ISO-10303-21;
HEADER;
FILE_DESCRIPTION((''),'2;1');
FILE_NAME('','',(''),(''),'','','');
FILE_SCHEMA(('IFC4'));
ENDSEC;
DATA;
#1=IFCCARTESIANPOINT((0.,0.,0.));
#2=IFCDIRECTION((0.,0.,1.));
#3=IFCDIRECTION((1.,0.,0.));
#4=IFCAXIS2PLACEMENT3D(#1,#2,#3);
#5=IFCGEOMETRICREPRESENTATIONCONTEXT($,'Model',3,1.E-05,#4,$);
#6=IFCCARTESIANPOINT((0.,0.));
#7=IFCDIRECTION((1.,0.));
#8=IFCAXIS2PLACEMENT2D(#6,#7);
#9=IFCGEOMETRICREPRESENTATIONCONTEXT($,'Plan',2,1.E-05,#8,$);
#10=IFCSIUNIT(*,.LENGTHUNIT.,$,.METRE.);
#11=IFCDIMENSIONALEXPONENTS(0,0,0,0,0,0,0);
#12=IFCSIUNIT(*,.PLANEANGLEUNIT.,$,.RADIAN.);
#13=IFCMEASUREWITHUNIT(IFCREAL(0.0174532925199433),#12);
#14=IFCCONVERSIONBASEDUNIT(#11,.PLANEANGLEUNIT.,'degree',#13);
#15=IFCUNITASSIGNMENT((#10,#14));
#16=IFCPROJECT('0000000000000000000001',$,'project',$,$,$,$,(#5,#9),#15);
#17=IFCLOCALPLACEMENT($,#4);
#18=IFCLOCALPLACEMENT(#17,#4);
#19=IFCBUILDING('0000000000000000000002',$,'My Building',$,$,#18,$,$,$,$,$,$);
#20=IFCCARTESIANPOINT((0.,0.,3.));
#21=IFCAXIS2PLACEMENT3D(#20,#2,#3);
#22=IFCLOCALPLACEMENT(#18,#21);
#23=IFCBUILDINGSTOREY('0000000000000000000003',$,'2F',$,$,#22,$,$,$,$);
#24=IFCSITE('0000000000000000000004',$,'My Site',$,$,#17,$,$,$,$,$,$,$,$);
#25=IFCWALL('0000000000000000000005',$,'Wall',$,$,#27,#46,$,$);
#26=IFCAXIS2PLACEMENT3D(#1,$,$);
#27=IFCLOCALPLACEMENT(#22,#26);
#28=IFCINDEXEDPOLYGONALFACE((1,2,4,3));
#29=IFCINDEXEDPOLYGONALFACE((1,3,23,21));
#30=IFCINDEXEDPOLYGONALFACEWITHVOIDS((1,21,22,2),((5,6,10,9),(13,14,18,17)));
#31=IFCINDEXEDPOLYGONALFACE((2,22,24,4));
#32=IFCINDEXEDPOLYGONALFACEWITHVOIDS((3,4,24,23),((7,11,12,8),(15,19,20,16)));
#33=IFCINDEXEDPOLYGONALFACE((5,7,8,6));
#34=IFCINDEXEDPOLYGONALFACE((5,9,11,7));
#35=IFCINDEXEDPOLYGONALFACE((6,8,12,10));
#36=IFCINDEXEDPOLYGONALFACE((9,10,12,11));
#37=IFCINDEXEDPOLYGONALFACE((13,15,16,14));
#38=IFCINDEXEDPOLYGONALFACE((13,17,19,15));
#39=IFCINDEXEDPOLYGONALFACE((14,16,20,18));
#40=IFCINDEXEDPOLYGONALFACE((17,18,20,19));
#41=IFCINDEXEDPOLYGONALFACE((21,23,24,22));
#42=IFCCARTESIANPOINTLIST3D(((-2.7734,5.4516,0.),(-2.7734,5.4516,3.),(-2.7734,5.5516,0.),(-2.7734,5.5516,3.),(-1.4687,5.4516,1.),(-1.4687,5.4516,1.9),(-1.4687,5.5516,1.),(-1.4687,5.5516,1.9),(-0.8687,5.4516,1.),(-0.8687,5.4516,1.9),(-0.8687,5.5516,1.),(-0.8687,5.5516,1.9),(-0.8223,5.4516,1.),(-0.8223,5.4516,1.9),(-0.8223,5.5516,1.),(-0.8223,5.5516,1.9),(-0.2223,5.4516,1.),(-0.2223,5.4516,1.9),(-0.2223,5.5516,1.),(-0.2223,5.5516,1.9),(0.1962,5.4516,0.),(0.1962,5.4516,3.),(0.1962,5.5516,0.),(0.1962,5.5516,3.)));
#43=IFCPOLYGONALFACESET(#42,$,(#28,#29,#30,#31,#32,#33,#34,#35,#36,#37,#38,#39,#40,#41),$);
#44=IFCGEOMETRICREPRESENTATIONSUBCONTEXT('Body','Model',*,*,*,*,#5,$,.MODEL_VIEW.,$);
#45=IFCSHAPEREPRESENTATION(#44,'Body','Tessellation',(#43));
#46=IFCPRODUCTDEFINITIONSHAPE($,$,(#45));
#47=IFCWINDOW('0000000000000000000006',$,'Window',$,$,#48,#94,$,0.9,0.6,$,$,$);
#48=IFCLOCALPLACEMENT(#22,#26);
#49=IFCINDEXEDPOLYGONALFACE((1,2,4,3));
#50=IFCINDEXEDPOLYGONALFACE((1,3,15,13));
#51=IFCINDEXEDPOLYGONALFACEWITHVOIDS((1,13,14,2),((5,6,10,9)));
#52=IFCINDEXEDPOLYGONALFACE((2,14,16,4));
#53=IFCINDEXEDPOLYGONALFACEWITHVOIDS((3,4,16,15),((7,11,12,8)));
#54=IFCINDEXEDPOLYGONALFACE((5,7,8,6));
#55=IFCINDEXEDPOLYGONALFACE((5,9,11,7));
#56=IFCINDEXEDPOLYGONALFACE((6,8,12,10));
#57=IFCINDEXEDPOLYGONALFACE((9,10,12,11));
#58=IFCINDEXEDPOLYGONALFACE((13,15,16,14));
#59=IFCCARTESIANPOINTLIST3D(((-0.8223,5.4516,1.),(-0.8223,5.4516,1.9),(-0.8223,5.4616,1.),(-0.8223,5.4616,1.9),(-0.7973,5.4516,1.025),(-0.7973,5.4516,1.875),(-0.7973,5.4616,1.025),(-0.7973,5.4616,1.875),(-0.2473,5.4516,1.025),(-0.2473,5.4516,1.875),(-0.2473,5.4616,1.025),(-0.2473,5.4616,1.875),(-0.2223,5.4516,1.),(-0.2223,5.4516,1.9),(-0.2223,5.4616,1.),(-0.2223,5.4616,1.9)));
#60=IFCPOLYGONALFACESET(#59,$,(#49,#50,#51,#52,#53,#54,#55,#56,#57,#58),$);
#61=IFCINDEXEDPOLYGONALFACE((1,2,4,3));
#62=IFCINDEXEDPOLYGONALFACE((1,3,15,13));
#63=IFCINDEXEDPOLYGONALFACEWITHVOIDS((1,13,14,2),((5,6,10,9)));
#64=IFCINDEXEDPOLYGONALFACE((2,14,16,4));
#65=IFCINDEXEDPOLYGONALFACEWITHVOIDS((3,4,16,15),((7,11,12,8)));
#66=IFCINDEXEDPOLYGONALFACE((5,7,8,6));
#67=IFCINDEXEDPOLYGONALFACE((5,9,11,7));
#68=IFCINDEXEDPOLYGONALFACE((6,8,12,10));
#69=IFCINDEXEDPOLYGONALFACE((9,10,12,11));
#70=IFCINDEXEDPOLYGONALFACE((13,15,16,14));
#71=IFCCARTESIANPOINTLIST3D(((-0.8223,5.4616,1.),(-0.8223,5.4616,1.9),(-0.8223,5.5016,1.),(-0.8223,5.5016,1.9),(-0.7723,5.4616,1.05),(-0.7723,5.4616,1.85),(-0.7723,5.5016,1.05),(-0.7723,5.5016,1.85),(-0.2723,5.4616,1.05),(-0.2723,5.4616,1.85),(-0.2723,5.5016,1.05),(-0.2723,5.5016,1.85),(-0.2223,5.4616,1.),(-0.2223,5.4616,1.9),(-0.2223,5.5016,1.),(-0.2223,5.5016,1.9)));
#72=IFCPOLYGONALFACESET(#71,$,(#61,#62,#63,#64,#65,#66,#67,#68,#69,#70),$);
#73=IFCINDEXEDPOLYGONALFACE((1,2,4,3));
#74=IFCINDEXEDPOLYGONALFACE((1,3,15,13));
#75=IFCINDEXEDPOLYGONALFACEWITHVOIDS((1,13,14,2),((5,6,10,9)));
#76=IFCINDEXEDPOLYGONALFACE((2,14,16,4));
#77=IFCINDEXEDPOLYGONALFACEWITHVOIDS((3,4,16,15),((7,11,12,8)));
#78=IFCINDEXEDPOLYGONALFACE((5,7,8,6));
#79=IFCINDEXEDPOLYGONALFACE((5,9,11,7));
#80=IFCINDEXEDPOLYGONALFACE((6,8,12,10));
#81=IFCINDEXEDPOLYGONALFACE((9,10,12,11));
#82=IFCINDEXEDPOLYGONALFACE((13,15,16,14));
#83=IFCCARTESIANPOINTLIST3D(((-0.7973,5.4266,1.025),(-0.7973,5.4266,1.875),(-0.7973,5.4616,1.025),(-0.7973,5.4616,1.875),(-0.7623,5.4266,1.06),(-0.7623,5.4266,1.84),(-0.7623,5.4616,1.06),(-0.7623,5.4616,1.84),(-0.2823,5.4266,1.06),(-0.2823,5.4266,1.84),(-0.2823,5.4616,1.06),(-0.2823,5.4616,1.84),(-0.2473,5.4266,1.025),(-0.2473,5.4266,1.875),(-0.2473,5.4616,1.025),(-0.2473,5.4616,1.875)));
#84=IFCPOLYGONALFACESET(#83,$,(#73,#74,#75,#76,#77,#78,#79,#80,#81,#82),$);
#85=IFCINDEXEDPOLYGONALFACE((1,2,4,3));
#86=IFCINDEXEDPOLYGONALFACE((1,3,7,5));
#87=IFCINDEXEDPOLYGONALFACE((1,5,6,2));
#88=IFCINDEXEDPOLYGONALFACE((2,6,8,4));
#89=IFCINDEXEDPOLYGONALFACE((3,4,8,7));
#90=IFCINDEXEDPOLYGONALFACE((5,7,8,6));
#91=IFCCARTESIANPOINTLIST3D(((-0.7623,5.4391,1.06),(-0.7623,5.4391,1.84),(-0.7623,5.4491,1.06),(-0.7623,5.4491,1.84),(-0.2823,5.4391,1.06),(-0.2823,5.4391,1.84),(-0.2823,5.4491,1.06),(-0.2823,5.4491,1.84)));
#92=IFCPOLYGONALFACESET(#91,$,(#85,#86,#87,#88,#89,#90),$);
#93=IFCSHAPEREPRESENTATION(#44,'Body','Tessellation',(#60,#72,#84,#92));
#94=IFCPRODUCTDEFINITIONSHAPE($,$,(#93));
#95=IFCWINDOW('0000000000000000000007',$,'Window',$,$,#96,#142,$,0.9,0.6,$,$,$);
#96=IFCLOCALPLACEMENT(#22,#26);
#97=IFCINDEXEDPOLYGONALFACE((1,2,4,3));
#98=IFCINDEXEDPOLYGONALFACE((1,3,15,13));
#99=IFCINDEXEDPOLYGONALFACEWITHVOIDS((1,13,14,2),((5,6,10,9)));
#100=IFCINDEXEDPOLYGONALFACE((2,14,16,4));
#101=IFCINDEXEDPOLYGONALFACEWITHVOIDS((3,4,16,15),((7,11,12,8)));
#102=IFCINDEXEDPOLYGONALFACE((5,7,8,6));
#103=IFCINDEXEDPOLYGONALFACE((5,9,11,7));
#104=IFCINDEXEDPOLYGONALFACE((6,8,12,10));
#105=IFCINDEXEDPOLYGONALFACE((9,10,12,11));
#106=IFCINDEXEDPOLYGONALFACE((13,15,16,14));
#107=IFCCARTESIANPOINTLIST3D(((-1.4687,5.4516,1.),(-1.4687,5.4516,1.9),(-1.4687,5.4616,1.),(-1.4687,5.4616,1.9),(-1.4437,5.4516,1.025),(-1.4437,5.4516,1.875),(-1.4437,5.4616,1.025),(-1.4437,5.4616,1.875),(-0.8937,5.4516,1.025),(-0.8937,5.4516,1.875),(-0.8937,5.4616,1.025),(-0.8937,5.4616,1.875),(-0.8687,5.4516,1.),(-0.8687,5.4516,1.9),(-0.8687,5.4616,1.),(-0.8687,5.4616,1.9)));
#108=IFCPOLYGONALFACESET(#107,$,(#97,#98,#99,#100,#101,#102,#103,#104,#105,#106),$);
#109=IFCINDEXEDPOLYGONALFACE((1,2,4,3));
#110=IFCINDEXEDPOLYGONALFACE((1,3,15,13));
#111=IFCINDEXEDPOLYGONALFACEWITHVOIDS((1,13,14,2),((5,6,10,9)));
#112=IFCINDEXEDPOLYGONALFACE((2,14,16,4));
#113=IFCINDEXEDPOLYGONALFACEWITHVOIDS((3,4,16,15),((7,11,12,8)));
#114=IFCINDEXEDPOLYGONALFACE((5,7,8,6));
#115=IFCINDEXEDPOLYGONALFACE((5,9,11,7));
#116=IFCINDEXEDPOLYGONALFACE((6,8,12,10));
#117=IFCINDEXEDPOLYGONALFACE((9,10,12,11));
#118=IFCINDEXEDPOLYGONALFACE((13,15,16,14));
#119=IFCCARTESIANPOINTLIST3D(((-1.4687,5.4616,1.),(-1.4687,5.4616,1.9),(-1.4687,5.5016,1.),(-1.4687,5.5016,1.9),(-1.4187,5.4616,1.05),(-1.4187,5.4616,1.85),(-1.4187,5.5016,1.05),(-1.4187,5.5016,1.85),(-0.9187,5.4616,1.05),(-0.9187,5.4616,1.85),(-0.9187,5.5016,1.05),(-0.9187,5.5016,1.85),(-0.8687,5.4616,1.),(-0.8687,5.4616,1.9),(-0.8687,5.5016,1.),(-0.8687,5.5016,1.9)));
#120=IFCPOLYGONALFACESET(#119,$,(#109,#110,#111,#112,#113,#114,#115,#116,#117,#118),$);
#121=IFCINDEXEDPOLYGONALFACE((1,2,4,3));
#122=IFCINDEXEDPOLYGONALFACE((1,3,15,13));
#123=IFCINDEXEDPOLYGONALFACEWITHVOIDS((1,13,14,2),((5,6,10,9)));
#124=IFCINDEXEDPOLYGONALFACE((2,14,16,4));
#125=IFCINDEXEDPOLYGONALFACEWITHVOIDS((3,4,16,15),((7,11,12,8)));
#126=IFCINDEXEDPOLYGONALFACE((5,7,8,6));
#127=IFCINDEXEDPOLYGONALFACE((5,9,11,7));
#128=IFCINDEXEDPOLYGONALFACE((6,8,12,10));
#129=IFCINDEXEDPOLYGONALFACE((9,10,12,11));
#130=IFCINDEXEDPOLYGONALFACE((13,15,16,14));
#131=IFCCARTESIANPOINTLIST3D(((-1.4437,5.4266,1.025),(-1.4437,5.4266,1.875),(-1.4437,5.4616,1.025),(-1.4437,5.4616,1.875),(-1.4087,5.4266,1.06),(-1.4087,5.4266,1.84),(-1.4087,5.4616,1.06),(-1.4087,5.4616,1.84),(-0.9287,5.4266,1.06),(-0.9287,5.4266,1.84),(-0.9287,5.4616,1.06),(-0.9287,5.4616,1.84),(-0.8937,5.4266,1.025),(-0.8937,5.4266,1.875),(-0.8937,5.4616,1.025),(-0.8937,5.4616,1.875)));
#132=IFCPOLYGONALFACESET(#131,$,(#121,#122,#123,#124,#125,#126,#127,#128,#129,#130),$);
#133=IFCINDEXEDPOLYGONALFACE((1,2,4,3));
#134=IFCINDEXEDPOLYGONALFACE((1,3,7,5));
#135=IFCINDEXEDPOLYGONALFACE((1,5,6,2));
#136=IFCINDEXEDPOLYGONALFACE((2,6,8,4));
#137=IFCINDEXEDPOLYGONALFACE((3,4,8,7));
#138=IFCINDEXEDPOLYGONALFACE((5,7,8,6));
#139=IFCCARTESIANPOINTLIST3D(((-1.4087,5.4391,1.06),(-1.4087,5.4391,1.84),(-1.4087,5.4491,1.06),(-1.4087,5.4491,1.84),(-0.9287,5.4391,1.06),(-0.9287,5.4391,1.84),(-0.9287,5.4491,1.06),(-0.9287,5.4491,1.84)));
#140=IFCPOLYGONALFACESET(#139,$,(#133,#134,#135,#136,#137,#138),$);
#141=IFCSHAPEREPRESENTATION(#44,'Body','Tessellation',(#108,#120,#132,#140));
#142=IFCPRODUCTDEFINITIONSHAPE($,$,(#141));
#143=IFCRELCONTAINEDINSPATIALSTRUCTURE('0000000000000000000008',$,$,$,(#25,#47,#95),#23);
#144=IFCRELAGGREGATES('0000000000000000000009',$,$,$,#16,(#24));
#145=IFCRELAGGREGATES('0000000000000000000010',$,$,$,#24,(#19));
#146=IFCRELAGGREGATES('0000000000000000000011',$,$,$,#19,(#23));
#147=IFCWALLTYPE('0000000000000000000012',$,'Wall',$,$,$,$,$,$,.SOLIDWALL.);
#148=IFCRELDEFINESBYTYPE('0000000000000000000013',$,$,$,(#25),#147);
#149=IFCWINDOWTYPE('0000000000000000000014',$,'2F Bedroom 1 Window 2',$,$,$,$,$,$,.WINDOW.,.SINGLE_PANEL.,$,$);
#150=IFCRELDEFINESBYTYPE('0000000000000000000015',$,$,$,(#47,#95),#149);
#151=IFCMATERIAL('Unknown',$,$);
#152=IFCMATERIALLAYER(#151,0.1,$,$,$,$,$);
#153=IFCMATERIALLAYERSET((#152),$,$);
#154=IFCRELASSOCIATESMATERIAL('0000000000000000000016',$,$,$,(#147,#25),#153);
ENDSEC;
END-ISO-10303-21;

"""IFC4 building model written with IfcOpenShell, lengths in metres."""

from ifc_helpers import new_model, entity, si_unit, converted_unit, frame, origin_with_axes, origin_2d_with_axis, place, context, subcontext, project, spatial, line, indexed_curve, outline, extrude, shape, source, transform, mapped, material, layer, layer_set, layer_usage, type_object, type_shapes, element, fill, save


model = new_model("IFC4")

# Units and contexts
model_context = context("Model", 3, precision=1e-05, world=origin_with_axes())
plan_context = context("Plan", 2, precision=1e-05, world=origin_2d_with_axis())
body_context_1 = subcontext(model_context, "Body", "Model", "MODEL_VIEW")
body_context_2 = subcontext(plan_context, "Body", "Plan", "PLAN_VIEW")
ifc_project = project(units=[si_unit("LENGTHUNIT", "METRE"), converted_unit("PLANEANGLEUNIT", "degree", entity("IfcReal", 0.0174532925199433), si_unit("PLANEANGLEUNIT", "RADIAN"), dimensions=[0, 0, 0, 0, 0, 0, 0])], contexts=[model_context, plan_context])

# Site, building, storey
site_placement = place(None, origin_with_axes())
site = spatial("IfcSite", under=ifc_project, at=site_placement, Name="My Site")
building_placement = place(site_placement, origin_with_axes())
building = spatial("IfcBuilding", under=site, at=building_placement, Name="My Building")
storey_placement = place(building_placement, frame((0.0, 0.0, 3.0), z_axis=(0.0, 0.0, 1.0), x_axis=(1.0, 0.0, 0.0)))
storey = spatial("IfcBuildingStorey", under=building, at=storey_placement, Name="2F")

# Shared definitions
ifc_material = material(Name="Unknown")

# Shared definitions
ifc_layer_1 = layer(ifc_material, 0.1)
ifc_layer_set_1 = layer_set([ifc_layer_1])
wall_type = type_object("IfcWallType", Name="Wall", PredefinedType="SOLIDWALL", material=ifc_layer_set_1)

# Wall, openings, windows
ifc_layer_usage_1 = layer_usage(ifc_layer_set_1, "AXIS2", "POSITIVE", 0.0)
wall_1_placement = place(storey_placement, frame((0.1962, 5.5516, 0.0), z_axis=(0.0, 0.0, 1.0), x_axis=(-1.0, 0.0, 0.0)))
wall_1 = element("IfcWall", 1, at=wall_1_placement, inside=storey, type_object=wall_type, material=ifc_layer_usage_1, Name="Wall", context=body_context_1, shape_type="SweptSolid", body=[
    extrude(outline(indexed_curve([(0.0, 0.0), (0.0, 0.1), (2.9696, 0.1), (2.9696, 0.0)], segments=[line(1, 2, 3, 4, 1)])), origin_with_axes(), (0.0, 0.0, 1.0), 3.0),
])
shared_shape_1 = source(origin_with_axes(), body_context_1, "Body", "SweptSolid", [
    extrude(outline(indexed_curve([(0.0, 0.0), (0.6, 0.0), (0.6, 0.9), (0.0, 0.9)], segments=[line(1, 2, 3, 4, 1)])), frame((0.0, -0.6, 0.0), z_axis=(0.0, -1.0, 0.0), x_axis=(1.0, 0.0, 0.0)), (0.0, 0.0, -1.0), 1.2),
])
opening_1_placement = place(wall_1_placement, frame((0.4185, 0.0, 1.0), z_axis=(0.0, 0.0, 1.0), x_axis=(1.0, 0.0, 0.0)))
opening_1 = element("IfcOpeningElement", 2, at=opening_1_placement, cuts=wall_1, PredefinedType="OPENING", context=body_context_1, shape_type="MappedRepresentation", body=[
    mapped(shared_shape_1, transform((0.0, 0.0, 0.0), x_axis=(1.0, 0.0, 0.0), y_axis=(0.0, 1.0, 0.0), z_axis=(0.0, 0.0, 1.0), scale=1.0)),
])
opening_2_placement = place(wall_1_placement, frame((1.0649, 0.0, 1.0), z_axis=(0.0, 0.0, 1.0), x_axis=(1.0, 0.0, 0.0)))
opening_2 = element("IfcOpeningElement", 3, at=opening_2_placement, cuts=wall_1, PredefinedType="OPENING", context=body_context_1, shape_type="MappedRepresentation", body=[
    mapped(shared_shape_1, transform((0.0, 0.0, 0.0), x_axis=(1.0, 0.0, 0.0), y_axis=(0.0, 1.0, 0.0), z_axis=(0.0, 0.0, 1.0), scale=1.0)),
])
window_type_1 = type_object("IfcWindowType", Name="2F Bedroom 1 Window 2", PartitioningType="SINGLE_PANEL", PredefinedType="WINDOW")
shared_shape_2 = source(origin_with_axes(), body_context_1, "Body", "SweptSolid", [
    extrude(outline(indexed_curve([(0.0, 0.0), (0.6, 0.0), (0.6, 0.9), (0.0, 0.9)], segments=[line(1, 2, 3, 4, 1)]), holes=[indexed_curve([(0.025, 0.025), (0.575, 0.025), (0.575, 0.875), (0.025, 0.875)], segments=[line(1, 2, 3, 4, 1)])]), frame((0.0, 0.09, 0.0), z_axis=(0.0, -1.0, 0.0), x_axis=(1.0, 0.0, 0.0)), (0.0, 0.0, -1.0), 0.01),
    extrude(outline(indexed_curve([(0.0, 0.0), (0.6, 0.0), (0.6, 0.9), (0.0, 0.9)], segments=[line(1, 2, 3, 4, 1)]), holes=[indexed_curve([(0.05, 0.05), (0.55, 0.05), (0.55, 0.85), (0.05, 0.85)], segments=[line(1, 2, 3, 4, 1)])]), frame((0.0, 0.05, 0.0), z_axis=(0.0, -1.0, 0.0), x_axis=(1.0, 0.0, 0.0)), (0.0, 0.0, -1.0), 0.04),
    extrude(outline(indexed_curve([(0.0, 0.0), (0.55, 0.0), (0.55, 0.85), (0.0, 0.85)], segments=[line(1, 2, 3, 4, 1)]), holes=[indexed_curve([(0.035, 0.035), (0.515, 0.035), (0.515, 0.815), (0.035, 0.815)], segments=[line(1, 2, 3, 4, 1)])]), frame((0.025, 0.09, 0.025), z_axis=(0.0, -1.0, 0.0), x_axis=(1.0, 0.0, 0.0)), (0.0, 0.0, -1.0), 0.035),
    extrude(outline(indexed_curve([(0.035, 0.035), (0.515, 0.035), (0.515, 0.815), (0.035, 0.815)], segments=[line(1, 2, 3, 4, 1)])), frame((0.025, 0.1025, 0.025), z_axis=(0.0, -1.0, 0.0), x_axis=(1.0, 0.0, 0.0)), (0.0, 0.0, -1.0), 0.01),
])
shared_shape_3 = source(origin_with_axes(), body_context_2, "Body", "Curve2D", [
    entity("IfcIndexedPolyCurve", entity("IfcCartesianPointList2D", [[0.05, 0.05], [0.55, 0.05]])),
    entity("IfcIndexedPolyCurve", entity("IfcCartesianPointList2D", [[0.0, 0.1], [0.025, 0.1], [0.025, 0.09], [0.05, 0.09], [0.05, 0.05], [0.0, 0.05]]), [entity("IfcLineIndex", [1, 2, 3, 4, 5, 6, 1])]),
    entity("IfcIndexedPolyCurve", entity("IfcCartesianPointList2D", [[0.6, 0.1], [0.575, 0.1], [0.575, 0.09], [0.55, 0.09], [0.55, 0.05], [0.6, 0.05]]), [entity("IfcLineIndex", [1, 2, 3, 4, 5, 6, 1])]),
    entity("IfcIndexedPolyCurve", entity("IfcCartesianPointList2D", [[0.025, 0.09], [0.06, 0.09], [0.06, 0.125], [0.025, 0.125]]), [entity("IfcLineIndex", [1, 2, 3, 4, 1])]),
    entity("IfcIndexedPolyCurve", entity("IfcCartesianPointList2D", [[0.575, 0.09], [0.54, 0.09], [0.54, 0.125], [0.575, 0.125]]), [entity("IfcLineIndex", [1, 2, 3, 4, 1])]),
    entity("IfcIndexedPolyCurve", entity("IfcCartesianPointList2D", [[0.06, 0.09], [0.54, 0.09]])),
    entity("IfcIndexedPolyCurve", entity("IfcCartesianPointList2D", [[0.06, 0.125], [0.54, 0.125]])),
    entity("IfcIndexedPolyCurve", entity("IfcCartesianPointList2D", [[0.06, 0.1075], [0.54, 0.1075]])),
])
type_shapes(window_type_1, [shared_shape_2, shared_shape_3])
window_1_placement = place(opening_1_placement, frame((0.0, 0.0, 0.0), z_axis=(0.0, 0.0, 1.0), x_axis=(1.0, 0.0, 0.0)))
window_1 = element("IfcWindow", 4, at=window_1_placement, inside=storey, type_object=window_type_1, Name="Window", OverallHeight=0.9, OverallWidth=0.6, shapes=[
    shape(body_context_1, "Body", "MappedRepresentation", [mapped(shared_shape_2, transform((0.0, 0.0, 0.0), x_axis=(1.0, 0.0, 0.0), y_axis=(0.0, 1.0, 0.0), z_axis=(0.0, 0.0, 1.0), scale=1.0))]),
    shape(body_context_2, "Body", "MappedRepresentation", [mapped(shared_shape_3, transform((0.0, 0.0, 0.0), x_axis=(1.0, 0.0, 0.0), y_axis=(0.0, 1.0, 0.0), z_axis=(0.0, 0.0, 1.0), scale=1.0))]),
])
fill(opening_1, window_1)
window_2_placement = place(opening_2_placement, origin_with_axes())
window_2 = element("IfcWindow", 5, at=window_2_placement, inside=storey, type_object=window_type_1, Name="Window", OverallHeight=0.9, OverallWidth=0.6, shapes=[
    shape(body_context_1, "Body", "MappedRepresentation", [mapped(shared_shape_2, transform((0.0, 0.0, 0.0), x_axis=(1.0, 0.0, 0.0), y_axis=(0.0, 1.0, 0.0), z_axis=(0.0, 0.0, 1.0), scale=1.0))]),
    shape(body_context_2, "Body", "MappedRepresentation", [mapped(shared_shape_3, transform((0.0, 0.0, 0.0), x_axis=(1.0, 0.0, 0.0), y_axis=(0.0, 1.0, 0.0), z_axis=(0.0, 0.0, 1.0), scale=1.0))]),
])
fill(opening_2, window_2)

save(model, "model.ifc")
